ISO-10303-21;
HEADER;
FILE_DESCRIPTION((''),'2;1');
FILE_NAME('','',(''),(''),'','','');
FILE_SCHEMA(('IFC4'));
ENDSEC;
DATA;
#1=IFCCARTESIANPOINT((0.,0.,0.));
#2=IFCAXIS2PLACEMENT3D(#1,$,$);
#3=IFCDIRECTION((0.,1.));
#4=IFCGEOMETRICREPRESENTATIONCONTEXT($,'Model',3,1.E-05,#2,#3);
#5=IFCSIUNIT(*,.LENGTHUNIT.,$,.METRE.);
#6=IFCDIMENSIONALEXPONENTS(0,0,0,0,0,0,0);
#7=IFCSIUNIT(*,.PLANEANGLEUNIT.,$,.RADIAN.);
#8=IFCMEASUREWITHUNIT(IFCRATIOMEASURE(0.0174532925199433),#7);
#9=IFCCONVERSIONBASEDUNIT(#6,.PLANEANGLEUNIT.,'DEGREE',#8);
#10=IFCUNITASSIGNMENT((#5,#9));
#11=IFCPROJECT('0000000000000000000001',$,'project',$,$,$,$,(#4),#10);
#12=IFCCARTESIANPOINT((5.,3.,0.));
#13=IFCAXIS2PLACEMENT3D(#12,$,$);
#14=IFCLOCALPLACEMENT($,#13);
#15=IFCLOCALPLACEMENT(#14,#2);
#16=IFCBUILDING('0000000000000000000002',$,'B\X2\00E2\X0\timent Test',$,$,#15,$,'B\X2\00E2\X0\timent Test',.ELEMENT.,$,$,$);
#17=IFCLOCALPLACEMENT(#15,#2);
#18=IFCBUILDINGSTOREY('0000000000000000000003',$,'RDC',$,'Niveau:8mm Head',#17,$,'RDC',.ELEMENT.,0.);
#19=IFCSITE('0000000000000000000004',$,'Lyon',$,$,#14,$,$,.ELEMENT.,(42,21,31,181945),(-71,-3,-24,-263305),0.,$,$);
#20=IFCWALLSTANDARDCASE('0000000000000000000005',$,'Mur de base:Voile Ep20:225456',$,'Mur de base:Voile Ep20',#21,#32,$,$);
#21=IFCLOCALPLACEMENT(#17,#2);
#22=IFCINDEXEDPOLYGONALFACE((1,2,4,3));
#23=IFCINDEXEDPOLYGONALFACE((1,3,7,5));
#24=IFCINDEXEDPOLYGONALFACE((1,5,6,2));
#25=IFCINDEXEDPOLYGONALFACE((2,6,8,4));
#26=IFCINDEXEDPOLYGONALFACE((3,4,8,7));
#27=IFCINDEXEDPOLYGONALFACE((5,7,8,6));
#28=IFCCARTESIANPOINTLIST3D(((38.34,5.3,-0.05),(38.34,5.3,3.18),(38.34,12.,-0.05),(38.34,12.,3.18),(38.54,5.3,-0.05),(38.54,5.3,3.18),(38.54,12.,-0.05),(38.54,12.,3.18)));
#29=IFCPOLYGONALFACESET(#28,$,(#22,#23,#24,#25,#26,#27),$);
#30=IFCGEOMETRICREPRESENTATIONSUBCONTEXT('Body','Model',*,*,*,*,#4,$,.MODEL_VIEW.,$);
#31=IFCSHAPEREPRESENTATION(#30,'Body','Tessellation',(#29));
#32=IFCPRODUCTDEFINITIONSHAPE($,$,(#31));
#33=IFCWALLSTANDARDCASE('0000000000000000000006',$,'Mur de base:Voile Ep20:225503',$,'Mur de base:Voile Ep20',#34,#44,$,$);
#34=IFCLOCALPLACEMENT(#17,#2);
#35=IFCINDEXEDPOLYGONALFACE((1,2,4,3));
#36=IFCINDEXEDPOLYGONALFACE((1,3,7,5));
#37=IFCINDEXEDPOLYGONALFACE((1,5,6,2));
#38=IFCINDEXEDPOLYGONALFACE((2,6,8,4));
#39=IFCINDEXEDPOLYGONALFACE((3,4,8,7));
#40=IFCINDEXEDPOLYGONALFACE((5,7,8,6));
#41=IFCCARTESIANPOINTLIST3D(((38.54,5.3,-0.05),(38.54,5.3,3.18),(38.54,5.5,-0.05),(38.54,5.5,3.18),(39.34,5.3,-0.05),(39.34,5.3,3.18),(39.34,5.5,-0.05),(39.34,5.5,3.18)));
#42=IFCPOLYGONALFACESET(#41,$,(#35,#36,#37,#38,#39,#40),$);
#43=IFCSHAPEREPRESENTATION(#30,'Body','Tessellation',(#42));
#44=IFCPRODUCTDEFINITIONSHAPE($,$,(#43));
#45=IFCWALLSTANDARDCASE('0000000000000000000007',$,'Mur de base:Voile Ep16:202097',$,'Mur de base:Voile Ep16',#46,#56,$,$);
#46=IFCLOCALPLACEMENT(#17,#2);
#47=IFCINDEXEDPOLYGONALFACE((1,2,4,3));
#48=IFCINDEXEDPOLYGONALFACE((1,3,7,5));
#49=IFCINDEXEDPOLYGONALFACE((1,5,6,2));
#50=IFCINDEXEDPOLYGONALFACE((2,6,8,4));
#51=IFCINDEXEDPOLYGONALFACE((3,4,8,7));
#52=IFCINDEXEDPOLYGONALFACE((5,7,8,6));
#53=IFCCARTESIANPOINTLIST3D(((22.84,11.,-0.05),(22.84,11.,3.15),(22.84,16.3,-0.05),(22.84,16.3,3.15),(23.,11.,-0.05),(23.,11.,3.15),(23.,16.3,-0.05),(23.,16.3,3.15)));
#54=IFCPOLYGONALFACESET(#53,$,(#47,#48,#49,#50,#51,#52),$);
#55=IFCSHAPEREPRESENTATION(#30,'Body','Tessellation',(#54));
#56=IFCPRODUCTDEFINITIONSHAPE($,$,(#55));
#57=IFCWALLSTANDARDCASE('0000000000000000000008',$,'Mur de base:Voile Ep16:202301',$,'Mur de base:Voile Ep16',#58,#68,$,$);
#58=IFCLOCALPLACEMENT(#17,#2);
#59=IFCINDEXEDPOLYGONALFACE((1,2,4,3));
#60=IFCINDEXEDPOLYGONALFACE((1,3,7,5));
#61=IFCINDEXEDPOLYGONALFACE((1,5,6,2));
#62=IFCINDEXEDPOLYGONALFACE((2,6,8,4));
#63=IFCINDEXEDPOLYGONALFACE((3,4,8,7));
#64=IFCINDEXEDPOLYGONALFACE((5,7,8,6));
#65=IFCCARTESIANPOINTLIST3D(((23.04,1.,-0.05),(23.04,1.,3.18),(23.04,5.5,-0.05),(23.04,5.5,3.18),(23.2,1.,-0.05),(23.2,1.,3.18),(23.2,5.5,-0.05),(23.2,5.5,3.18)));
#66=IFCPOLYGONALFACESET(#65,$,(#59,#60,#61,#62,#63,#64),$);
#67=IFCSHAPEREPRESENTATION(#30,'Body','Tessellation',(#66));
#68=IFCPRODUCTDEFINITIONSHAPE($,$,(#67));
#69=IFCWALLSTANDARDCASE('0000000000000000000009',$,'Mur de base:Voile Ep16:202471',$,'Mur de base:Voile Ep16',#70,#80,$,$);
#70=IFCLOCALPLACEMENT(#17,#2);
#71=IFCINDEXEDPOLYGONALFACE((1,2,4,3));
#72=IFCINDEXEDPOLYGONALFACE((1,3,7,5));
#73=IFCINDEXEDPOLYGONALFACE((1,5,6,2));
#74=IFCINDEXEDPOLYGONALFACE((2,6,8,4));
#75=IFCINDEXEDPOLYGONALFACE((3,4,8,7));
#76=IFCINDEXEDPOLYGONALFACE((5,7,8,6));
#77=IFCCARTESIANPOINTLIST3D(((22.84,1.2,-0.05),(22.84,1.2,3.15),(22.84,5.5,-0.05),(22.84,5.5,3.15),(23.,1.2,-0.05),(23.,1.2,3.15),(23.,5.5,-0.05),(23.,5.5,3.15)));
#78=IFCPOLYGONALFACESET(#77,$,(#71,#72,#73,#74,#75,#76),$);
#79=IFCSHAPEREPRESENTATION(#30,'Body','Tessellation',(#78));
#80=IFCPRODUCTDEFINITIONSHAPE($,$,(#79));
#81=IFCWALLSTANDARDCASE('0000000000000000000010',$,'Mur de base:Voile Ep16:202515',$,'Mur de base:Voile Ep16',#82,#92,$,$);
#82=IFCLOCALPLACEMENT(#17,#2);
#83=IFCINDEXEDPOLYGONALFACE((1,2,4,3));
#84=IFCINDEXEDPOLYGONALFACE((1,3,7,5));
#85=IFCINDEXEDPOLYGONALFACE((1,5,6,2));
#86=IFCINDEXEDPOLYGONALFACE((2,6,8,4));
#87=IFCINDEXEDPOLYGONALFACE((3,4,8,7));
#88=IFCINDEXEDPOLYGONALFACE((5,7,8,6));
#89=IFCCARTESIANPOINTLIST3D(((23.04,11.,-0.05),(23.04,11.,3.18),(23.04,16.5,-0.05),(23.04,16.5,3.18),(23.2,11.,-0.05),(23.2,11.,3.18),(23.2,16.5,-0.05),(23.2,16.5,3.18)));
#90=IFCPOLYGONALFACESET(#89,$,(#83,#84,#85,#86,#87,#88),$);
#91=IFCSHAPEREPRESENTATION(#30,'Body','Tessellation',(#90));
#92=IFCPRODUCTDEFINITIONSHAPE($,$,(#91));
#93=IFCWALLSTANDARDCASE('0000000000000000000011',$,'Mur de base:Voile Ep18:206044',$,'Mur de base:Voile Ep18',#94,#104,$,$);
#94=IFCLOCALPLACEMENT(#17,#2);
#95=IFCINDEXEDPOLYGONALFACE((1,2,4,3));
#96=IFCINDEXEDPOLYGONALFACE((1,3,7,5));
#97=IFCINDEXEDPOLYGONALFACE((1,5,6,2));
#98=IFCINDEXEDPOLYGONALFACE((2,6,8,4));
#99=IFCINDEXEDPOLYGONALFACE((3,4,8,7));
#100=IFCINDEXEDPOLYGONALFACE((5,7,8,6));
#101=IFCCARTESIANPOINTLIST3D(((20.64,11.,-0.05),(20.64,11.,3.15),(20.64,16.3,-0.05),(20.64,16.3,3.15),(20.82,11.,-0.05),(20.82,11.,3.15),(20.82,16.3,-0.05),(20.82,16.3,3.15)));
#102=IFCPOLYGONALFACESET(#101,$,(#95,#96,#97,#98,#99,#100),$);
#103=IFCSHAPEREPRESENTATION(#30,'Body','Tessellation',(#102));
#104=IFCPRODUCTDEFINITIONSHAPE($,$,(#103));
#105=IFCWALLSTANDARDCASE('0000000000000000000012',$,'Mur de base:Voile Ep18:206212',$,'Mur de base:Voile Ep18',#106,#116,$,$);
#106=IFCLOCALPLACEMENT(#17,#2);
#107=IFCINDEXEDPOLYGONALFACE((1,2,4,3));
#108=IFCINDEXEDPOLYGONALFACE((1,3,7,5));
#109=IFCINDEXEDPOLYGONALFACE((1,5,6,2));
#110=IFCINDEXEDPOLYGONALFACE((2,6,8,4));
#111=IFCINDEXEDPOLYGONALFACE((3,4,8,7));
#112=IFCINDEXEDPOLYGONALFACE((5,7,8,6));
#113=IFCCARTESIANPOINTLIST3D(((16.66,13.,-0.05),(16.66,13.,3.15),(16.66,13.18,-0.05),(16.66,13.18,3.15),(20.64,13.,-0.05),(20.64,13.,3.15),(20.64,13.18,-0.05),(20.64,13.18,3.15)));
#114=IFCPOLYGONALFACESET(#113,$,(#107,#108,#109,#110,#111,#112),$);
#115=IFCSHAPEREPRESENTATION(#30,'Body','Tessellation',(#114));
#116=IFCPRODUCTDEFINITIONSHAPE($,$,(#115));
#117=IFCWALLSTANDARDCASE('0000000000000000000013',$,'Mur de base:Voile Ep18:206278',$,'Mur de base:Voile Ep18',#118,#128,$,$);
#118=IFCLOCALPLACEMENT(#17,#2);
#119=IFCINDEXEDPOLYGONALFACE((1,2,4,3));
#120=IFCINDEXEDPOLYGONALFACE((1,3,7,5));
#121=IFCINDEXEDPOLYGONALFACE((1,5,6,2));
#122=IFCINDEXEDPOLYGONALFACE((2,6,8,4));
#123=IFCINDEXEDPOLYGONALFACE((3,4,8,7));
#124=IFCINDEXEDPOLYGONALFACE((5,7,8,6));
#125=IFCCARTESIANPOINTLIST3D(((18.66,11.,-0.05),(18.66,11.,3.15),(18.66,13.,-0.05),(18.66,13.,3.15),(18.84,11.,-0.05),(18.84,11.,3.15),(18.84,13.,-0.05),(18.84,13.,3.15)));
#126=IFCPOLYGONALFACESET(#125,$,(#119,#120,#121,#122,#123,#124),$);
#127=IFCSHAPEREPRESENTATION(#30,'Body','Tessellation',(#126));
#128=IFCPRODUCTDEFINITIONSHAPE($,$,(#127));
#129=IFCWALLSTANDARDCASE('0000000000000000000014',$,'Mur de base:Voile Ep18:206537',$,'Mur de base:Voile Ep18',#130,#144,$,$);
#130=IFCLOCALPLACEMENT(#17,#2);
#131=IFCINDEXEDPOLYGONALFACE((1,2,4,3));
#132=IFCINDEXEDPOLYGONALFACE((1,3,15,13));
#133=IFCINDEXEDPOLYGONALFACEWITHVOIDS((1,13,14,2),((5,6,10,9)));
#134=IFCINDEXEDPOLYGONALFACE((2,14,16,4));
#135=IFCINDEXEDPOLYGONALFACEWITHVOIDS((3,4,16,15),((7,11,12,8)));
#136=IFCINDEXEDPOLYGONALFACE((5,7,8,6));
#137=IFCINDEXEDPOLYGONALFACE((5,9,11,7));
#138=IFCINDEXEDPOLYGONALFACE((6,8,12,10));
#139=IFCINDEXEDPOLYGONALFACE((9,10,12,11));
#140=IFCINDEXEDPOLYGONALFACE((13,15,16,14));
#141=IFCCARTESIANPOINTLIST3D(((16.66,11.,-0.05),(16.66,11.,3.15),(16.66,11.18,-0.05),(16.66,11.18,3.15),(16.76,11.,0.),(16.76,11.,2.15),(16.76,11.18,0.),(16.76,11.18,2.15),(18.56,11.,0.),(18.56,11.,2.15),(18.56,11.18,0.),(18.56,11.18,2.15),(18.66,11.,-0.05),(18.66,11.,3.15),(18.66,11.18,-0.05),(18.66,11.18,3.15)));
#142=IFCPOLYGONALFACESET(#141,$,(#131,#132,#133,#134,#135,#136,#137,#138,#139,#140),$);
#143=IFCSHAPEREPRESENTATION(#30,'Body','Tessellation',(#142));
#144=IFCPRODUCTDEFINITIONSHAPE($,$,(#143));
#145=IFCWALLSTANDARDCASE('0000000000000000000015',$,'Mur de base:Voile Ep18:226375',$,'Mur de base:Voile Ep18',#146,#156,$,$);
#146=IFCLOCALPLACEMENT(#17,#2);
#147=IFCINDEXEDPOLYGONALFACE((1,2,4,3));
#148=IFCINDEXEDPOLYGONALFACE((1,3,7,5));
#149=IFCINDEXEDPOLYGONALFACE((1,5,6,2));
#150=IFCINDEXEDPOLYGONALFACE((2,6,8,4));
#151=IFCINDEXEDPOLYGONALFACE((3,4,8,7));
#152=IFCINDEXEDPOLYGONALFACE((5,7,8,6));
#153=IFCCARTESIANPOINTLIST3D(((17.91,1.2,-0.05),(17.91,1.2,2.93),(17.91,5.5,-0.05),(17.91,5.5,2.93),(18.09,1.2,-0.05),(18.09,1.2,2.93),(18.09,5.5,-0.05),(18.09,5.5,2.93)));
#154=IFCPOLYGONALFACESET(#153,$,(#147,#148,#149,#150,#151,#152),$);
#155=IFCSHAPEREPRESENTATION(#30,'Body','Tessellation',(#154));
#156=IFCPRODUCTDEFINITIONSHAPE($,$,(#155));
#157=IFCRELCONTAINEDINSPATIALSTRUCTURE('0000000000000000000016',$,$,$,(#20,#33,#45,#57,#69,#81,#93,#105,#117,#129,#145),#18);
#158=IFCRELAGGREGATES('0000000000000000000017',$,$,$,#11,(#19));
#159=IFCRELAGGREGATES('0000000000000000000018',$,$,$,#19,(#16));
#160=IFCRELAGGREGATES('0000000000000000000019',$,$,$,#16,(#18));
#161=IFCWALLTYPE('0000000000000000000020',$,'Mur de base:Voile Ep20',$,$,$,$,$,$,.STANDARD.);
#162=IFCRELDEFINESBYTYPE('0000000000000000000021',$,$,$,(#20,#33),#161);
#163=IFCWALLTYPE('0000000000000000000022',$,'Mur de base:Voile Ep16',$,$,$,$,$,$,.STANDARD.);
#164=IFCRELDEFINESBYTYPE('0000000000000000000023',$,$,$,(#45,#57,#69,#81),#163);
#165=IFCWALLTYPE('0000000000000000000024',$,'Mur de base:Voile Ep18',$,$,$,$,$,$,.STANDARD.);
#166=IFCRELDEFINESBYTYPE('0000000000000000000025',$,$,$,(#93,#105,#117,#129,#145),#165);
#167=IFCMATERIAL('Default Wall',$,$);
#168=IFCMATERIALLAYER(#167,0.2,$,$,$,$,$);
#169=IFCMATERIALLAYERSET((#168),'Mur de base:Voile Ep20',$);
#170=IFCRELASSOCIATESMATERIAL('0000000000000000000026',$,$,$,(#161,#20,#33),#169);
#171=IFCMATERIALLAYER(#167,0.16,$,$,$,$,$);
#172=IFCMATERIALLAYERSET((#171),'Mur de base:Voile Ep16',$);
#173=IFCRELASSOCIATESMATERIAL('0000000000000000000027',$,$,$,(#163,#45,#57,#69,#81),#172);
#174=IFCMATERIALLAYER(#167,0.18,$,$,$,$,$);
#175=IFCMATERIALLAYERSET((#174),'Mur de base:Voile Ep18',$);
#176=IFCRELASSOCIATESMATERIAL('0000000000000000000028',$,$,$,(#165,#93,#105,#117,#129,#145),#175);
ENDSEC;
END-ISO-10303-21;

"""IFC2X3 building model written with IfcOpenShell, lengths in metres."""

from ifc_helpers import new_model, entity, si_unit, converted_unit, direction, frame, frame_2d, origin, place, context, subcontext, project, spatial, rectangle, extrude, material, layer, layer_set, layer_usage, type_object, element, save


model = new_model("IFC2X3")

# Units and contexts
model_context = context("Model", 3, precision=1e-05, world=origin(), true_north=direction((0.0, 1.0)))
body_context = subcontext(model_context, "Body", "Model", "MODEL_VIEW")
ifc_project = project(units=[si_unit("LENGTHUNIT", "METRE"), converted_unit("PLANEANGLEUNIT", "DEGREE", entity("IfcRatioMeasure", 0.0174532925199433), si_unit("PLANEANGLEUNIT", "RADIAN"), dimensions=[0, 0, 0, 0, 0, 0, 0])], contexts=[model_context])

# Site, building, storey
site_placement = place(None, frame((5.0, 3.0, 0.0)))
site = spatial("IfcSite", under=ifc_project, at=site_placement, Name="Lyon", CompositionType="ELEMENT", RefLatitude=(42, 21, 31, 181945), RefLongitude=(-71, -3, -24, -263305), RefElevation=0.0)
building_placement = place(site_placement, origin())
building = spatial("IfcBuilding", under=site, at=building_placement, Name="Bâtiment Test", LongName="Bâtiment Test", CompositionType="ELEMENT")
storey_placement = place(building_placement, origin())
storey = spatial("IfcBuildingStorey", under=building, at=storey_placement, Name="RDC", ObjectType="Niveau:8mm Head", LongName="RDC", CompositionType="ELEMENT", Elevation=0.0)

# Shared definitions
ifc_material_1 = material(Name="Default Wall")
ifc_layer_1 = layer(ifc_material_1, 0.2)
ifc_layer_set_1 = layer_set([ifc_layer_1], Name="Mur de base:Voile Ep20")
wall_type_1 = type_object("IfcWallType", Name="Mur de base:Voile Ep20", PredefinedType="STANDARD", material=ifc_layer_set_1)

# Walls
ifc_layer_usage_1 = layer_usage(ifc_layer_set_1, "AXIS2", "NEGATIVE", 0.1)
wall_1_placement = place(storey_placement, frame((38.44, 12.0, -0.05), z_axis=(0.0, 0.0, 1.0), x_axis=(0.0, -1.0, 0.0)))
element("IfcWallStandardCase", 1, at=wall_1_placement, inside=storey, type_object=wall_type_1, material=ifc_layer_usage_1, Name="Mur de base:Voile Ep20:225456", ObjectType="Mur de base:Voile Ep20", context=body_context, shape_type="SweptSolid", body=[
    extrude(rectangle(XDim=6.7, YDim=0.2, at=frame_2d((3.35, 0.0), x_axis=(-1.0, 0.0))), origin(), (0.0, 0.0, 1.0), 3.23),
])
ifc_layer_usage_2 = layer_usage(ifc_layer_set_1, "AXIS2", "NEGATIVE", 0.1)
wall_2_placement = place(storey_placement, frame((38.54, 5.4, -0.05)))
element("IfcWallStandardCase", 2, at=wall_2_placement, inside=storey, type_object=wall_type_1, material=ifc_layer_usage_2, Name="Mur de base:Voile Ep20:225503", ObjectType="Mur de base:Voile Ep20", context=body_context, shape_type="SweptSolid", body=[
    extrude(rectangle(XDim=0.8, YDim=0.2, at=frame_2d((0.4, 0.0), x_axis=(-1.0, 0.0))), origin(), (0.0, 0.0, 1.0), 3.23),
])
ifc_layer_2 = layer(ifc_material_1, 0.16)
ifc_layer_set_2 = layer_set([ifc_layer_2], Name="Mur de base:Voile Ep16")
ifc_layer_usage_3 = layer_usage(ifc_layer_set_2, "AXIS2", "NEGATIVE", 0.08)
wall_type_2 = type_object("IfcWallType", Name="Mur de base:Voile Ep16", PredefinedType="STANDARD", material=ifc_layer_set_2)
wall_3_placement = place(storey_placement, frame((22.92, 16.3, -0.05), z_axis=(0.0, 0.0, 1.0), x_axis=(0.0, -1.0, 0.0)))
element("IfcWallStandardCase", 3, at=wall_3_placement, inside=storey, type_object=wall_type_2, material=ifc_layer_usage_3, Name="Mur de base:Voile Ep16:202097", ObjectType="Mur de base:Voile Ep16", context=body_context, shape_type="SweptSolid", body=[
    extrude(rectangle(XDim=5.3, YDim=0.16, at=frame_2d((2.65, 0.0), x_axis=(-1.0, 0.0))), origin(), (0.0, 0.0, 1.0), 3.2),
])
ifc_layer_usage_4 = layer_usage(ifc_layer_set_2, "AXIS2", "NEGATIVE", 0.08)
wall_4_placement = place(storey_placement, frame((23.12, 1.0, -0.05), z_axis=(0.0, 0.0, 1.0), x_axis=(0.0, 1.0, 0.0)))
element("IfcWallStandardCase", 4, at=wall_4_placement, inside=storey, type_object=wall_type_2, material=ifc_layer_usage_4, Name="Mur de base:Voile Ep16:202301", ObjectType="Mur de base:Voile Ep16", context=body_context, shape_type="SweptSolid", body=[
    extrude(rectangle(XDim=4.5, YDim=0.16, at=frame_2d((2.25, 0.0), x_axis=(-1.0, 0.0))), origin(), (0.0, 0.0, 1.0), 3.23),
])
ifc_layer_usage_5 = layer_usage(ifc_layer_set_2, "AXIS2", "NEGATIVE", 0.08)
wall_5_placement = place(storey_placement, frame((22.92, 5.5, -0.05), z_axis=(0.0, 0.0, 1.0), x_axis=(0.0, -1.0, 0.0)))
element("IfcWallStandardCase", 5, at=wall_5_placement, inside=storey, type_object=wall_type_2, material=ifc_layer_usage_5, Name="Mur de base:Voile Ep16:202471", ObjectType="Mur de base:Voile Ep16", context=body_context, shape_type="SweptSolid", body=[
    extrude(rectangle(XDim=4.3, YDim=0.16, at=frame_2d((2.15, 0.0), x_axis=(-1.0, 0.0))), origin(), (0.0, 0.0, 1.0), 3.2),
])
ifc_layer_usage_6 = layer_usage(ifc_layer_set_2, "AXIS2", "NEGATIVE", 0.08)
wall_6_placement = place(storey_placement, frame((23.12, 11.0, -0.05), z_axis=(0.0, 0.0, 1.0), x_axis=(0.0, 1.0, 0.0)))
element("IfcWallStandardCase", 6, at=wall_6_placement, inside=storey, type_object=wall_type_2, material=ifc_layer_usage_6, Name="Mur de base:Voile Ep16:202515", ObjectType="Mur de base:Voile Ep16", context=body_context, shape_type="SweptSolid", body=[
    extrude(rectangle(XDim=5.5, YDim=0.16, at=frame_2d((2.75, 0.0), x_axis=(-1.0, 0.0))), origin(), (0.0, 0.0, 1.0), 3.23),
])
ifc_layer_3 = layer(ifc_material_1, 0.18)
ifc_layer_set_3 = layer_set([ifc_layer_3], Name="Mur de base:Voile Ep18")
ifc_layer_usage_7 = layer_usage(ifc_layer_set_3, "AXIS2", "NEGATIVE", 0.09)
wall_type_3 = type_object("IfcWallType", Name="Mur de base:Voile Ep18", PredefinedType="STANDARD", material=ifc_layer_set_3)
wall_7_placement = place(storey_placement, frame((20.73, 16.3, -0.05), z_axis=(0.0, 0.0, 1.0), x_axis=(0.0, -1.0, 0.0)))
element("IfcWallStandardCase", 7, at=wall_7_placement, inside=storey, type_object=wall_type_3, material=ifc_layer_usage_7, Name="Mur de base:Voile Ep18:206044", ObjectType="Mur de base:Voile Ep18", context=body_context, shape_type="SweptSolid", body=[
    extrude(rectangle(XDim=5.3, YDim=0.18, at=frame_2d((2.65, 0.0), x_axis=(-1.0, 0.0))), origin(), (0.0, 0.0, 1.0), 3.2),
])
ifc_layer_usage_8 = layer_usage(ifc_layer_set_3, "AXIS2", "NEGATIVE", 0.09)
wall_8_placement = place(storey_placement, frame((20.64, 13.09, -0.05), z_axis=(0.0, 0.0, 1.0), x_axis=(-1.0, 0.0, 0.0)))
element("IfcWallStandardCase", 8, at=wall_8_placement, inside=storey, type_object=wall_type_3, material=ifc_layer_usage_8, Name="Mur de base:Voile Ep18:206212", ObjectType="Mur de base:Voile Ep18", context=body_context, shape_type="SweptSolid", body=[
    extrude(rectangle(XDim=3.98, YDim=0.18, at=frame_2d((1.99, 0.0), x_axis=(-1.0, 0.0))), origin(), (0.0, 0.0, 1.0), 3.2),
])
ifc_layer_usage_9 = layer_usage(ifc_layer_set_3, "AXIS2", "NEGATIVE", 0.09)
wall_9_placement = place(storey_placement, frame((18.75, 13.0, -0.05), z_axis=(0.0, 0.0, 1.0), x_axis=(0.0, -1.0, 0.0)))
element("IfcWallStandardCase", 9, at=wall_9_placement, inside=storey, type_object=wall_type_3, material=ifc_layer_usage_9, Name="Mur de base:Voile Ep18:206278", ObjectType="Mur de base:Voile Ep18", context=body_context, shape_type="SweptSolid", body=[
    extrude(rectangle(XDim=2.0, YDim=0.18, at=frame_2d((1.0, 0.0), x_axis=(-1.0, 0.0))), origin(), (0.0, 0.0, 1.0), 3.2),
])

# Wall, opening
ifc_layer_usage_10 = layer_usage(ifc_layer_set_3, "AXIS2", "POSITIVE", -0.09)
wall_10_placement = place(storey_placement, frame((16.66, 11.09, -0.05)))
wall_10 = element("IfcWallStandardCase", 10, at=wall_10_placement, inside=storey, type_object=wall_type_3, material=ifc_layer_usage_10, Name="Mur de base:Voile Ep18:206537", ObjectType="Mur de base:Voile Ep18", context=body_context, shape_type="SweptSolid", body=[
    extrude(rectangle(XDim=2.0, YDim=0.18, at=frame_2d((1.0, 0.0), x_axis=(-1.0, 0.0))), origin(), (0.0, 0.0, 1.0), 3.2),
])
opening_1_placement = place(wall_10_placement, origin())
element("IfcOpeningElement", 11, at=opening_1_placement, cuts=wall_10, ObjectType="Opening", context=body_context, shape_type="SweptSolid", body=[
    extrude(rectangle(XDim=2.15, YDim=1.8, at=frame_2d((0.0, 0.0), x_axis=(0.0, 1.0))), frame((1.0, -0.09, 1.125), z_axis=(0.0, 1.0, 0.0), x_axis=(1.0, 0.0, 0.0)), (0.0, 0.0, 1.0), 0.18),
])

# Wall
ifc_layer_usage_11 = layer_usage(ifc_layer_set_3, "AXIS2", "NEGATIVE", 0.09)
wall_11_placement = place(storey_placement, frame((18.0, 1.2, -0.05), z_axis=(0.0, 0.0, 1.0), x_axis=(0.0, 1.0, 0.0)))
element("IfcWallStandardCase", 12, at=wall_11_placement, inside=storey, type_object=wall_type_3, material=ifc_layer_usage_11, Name="Mur de base:Voile Ep18:226375", ObjectType="Mur de base:Voile Ep18", context=body_context, shape_type="SweptSolid", body=[
    extrude(rectangle(XDim=4.3, YDim=0.18, at=frame_2d((2.15, 0.0), x_axis=(-1.0, 0.0))), origin(), (0.0, 0.0, 1.0), 2.98),
])

save(model, "model.ifc")
